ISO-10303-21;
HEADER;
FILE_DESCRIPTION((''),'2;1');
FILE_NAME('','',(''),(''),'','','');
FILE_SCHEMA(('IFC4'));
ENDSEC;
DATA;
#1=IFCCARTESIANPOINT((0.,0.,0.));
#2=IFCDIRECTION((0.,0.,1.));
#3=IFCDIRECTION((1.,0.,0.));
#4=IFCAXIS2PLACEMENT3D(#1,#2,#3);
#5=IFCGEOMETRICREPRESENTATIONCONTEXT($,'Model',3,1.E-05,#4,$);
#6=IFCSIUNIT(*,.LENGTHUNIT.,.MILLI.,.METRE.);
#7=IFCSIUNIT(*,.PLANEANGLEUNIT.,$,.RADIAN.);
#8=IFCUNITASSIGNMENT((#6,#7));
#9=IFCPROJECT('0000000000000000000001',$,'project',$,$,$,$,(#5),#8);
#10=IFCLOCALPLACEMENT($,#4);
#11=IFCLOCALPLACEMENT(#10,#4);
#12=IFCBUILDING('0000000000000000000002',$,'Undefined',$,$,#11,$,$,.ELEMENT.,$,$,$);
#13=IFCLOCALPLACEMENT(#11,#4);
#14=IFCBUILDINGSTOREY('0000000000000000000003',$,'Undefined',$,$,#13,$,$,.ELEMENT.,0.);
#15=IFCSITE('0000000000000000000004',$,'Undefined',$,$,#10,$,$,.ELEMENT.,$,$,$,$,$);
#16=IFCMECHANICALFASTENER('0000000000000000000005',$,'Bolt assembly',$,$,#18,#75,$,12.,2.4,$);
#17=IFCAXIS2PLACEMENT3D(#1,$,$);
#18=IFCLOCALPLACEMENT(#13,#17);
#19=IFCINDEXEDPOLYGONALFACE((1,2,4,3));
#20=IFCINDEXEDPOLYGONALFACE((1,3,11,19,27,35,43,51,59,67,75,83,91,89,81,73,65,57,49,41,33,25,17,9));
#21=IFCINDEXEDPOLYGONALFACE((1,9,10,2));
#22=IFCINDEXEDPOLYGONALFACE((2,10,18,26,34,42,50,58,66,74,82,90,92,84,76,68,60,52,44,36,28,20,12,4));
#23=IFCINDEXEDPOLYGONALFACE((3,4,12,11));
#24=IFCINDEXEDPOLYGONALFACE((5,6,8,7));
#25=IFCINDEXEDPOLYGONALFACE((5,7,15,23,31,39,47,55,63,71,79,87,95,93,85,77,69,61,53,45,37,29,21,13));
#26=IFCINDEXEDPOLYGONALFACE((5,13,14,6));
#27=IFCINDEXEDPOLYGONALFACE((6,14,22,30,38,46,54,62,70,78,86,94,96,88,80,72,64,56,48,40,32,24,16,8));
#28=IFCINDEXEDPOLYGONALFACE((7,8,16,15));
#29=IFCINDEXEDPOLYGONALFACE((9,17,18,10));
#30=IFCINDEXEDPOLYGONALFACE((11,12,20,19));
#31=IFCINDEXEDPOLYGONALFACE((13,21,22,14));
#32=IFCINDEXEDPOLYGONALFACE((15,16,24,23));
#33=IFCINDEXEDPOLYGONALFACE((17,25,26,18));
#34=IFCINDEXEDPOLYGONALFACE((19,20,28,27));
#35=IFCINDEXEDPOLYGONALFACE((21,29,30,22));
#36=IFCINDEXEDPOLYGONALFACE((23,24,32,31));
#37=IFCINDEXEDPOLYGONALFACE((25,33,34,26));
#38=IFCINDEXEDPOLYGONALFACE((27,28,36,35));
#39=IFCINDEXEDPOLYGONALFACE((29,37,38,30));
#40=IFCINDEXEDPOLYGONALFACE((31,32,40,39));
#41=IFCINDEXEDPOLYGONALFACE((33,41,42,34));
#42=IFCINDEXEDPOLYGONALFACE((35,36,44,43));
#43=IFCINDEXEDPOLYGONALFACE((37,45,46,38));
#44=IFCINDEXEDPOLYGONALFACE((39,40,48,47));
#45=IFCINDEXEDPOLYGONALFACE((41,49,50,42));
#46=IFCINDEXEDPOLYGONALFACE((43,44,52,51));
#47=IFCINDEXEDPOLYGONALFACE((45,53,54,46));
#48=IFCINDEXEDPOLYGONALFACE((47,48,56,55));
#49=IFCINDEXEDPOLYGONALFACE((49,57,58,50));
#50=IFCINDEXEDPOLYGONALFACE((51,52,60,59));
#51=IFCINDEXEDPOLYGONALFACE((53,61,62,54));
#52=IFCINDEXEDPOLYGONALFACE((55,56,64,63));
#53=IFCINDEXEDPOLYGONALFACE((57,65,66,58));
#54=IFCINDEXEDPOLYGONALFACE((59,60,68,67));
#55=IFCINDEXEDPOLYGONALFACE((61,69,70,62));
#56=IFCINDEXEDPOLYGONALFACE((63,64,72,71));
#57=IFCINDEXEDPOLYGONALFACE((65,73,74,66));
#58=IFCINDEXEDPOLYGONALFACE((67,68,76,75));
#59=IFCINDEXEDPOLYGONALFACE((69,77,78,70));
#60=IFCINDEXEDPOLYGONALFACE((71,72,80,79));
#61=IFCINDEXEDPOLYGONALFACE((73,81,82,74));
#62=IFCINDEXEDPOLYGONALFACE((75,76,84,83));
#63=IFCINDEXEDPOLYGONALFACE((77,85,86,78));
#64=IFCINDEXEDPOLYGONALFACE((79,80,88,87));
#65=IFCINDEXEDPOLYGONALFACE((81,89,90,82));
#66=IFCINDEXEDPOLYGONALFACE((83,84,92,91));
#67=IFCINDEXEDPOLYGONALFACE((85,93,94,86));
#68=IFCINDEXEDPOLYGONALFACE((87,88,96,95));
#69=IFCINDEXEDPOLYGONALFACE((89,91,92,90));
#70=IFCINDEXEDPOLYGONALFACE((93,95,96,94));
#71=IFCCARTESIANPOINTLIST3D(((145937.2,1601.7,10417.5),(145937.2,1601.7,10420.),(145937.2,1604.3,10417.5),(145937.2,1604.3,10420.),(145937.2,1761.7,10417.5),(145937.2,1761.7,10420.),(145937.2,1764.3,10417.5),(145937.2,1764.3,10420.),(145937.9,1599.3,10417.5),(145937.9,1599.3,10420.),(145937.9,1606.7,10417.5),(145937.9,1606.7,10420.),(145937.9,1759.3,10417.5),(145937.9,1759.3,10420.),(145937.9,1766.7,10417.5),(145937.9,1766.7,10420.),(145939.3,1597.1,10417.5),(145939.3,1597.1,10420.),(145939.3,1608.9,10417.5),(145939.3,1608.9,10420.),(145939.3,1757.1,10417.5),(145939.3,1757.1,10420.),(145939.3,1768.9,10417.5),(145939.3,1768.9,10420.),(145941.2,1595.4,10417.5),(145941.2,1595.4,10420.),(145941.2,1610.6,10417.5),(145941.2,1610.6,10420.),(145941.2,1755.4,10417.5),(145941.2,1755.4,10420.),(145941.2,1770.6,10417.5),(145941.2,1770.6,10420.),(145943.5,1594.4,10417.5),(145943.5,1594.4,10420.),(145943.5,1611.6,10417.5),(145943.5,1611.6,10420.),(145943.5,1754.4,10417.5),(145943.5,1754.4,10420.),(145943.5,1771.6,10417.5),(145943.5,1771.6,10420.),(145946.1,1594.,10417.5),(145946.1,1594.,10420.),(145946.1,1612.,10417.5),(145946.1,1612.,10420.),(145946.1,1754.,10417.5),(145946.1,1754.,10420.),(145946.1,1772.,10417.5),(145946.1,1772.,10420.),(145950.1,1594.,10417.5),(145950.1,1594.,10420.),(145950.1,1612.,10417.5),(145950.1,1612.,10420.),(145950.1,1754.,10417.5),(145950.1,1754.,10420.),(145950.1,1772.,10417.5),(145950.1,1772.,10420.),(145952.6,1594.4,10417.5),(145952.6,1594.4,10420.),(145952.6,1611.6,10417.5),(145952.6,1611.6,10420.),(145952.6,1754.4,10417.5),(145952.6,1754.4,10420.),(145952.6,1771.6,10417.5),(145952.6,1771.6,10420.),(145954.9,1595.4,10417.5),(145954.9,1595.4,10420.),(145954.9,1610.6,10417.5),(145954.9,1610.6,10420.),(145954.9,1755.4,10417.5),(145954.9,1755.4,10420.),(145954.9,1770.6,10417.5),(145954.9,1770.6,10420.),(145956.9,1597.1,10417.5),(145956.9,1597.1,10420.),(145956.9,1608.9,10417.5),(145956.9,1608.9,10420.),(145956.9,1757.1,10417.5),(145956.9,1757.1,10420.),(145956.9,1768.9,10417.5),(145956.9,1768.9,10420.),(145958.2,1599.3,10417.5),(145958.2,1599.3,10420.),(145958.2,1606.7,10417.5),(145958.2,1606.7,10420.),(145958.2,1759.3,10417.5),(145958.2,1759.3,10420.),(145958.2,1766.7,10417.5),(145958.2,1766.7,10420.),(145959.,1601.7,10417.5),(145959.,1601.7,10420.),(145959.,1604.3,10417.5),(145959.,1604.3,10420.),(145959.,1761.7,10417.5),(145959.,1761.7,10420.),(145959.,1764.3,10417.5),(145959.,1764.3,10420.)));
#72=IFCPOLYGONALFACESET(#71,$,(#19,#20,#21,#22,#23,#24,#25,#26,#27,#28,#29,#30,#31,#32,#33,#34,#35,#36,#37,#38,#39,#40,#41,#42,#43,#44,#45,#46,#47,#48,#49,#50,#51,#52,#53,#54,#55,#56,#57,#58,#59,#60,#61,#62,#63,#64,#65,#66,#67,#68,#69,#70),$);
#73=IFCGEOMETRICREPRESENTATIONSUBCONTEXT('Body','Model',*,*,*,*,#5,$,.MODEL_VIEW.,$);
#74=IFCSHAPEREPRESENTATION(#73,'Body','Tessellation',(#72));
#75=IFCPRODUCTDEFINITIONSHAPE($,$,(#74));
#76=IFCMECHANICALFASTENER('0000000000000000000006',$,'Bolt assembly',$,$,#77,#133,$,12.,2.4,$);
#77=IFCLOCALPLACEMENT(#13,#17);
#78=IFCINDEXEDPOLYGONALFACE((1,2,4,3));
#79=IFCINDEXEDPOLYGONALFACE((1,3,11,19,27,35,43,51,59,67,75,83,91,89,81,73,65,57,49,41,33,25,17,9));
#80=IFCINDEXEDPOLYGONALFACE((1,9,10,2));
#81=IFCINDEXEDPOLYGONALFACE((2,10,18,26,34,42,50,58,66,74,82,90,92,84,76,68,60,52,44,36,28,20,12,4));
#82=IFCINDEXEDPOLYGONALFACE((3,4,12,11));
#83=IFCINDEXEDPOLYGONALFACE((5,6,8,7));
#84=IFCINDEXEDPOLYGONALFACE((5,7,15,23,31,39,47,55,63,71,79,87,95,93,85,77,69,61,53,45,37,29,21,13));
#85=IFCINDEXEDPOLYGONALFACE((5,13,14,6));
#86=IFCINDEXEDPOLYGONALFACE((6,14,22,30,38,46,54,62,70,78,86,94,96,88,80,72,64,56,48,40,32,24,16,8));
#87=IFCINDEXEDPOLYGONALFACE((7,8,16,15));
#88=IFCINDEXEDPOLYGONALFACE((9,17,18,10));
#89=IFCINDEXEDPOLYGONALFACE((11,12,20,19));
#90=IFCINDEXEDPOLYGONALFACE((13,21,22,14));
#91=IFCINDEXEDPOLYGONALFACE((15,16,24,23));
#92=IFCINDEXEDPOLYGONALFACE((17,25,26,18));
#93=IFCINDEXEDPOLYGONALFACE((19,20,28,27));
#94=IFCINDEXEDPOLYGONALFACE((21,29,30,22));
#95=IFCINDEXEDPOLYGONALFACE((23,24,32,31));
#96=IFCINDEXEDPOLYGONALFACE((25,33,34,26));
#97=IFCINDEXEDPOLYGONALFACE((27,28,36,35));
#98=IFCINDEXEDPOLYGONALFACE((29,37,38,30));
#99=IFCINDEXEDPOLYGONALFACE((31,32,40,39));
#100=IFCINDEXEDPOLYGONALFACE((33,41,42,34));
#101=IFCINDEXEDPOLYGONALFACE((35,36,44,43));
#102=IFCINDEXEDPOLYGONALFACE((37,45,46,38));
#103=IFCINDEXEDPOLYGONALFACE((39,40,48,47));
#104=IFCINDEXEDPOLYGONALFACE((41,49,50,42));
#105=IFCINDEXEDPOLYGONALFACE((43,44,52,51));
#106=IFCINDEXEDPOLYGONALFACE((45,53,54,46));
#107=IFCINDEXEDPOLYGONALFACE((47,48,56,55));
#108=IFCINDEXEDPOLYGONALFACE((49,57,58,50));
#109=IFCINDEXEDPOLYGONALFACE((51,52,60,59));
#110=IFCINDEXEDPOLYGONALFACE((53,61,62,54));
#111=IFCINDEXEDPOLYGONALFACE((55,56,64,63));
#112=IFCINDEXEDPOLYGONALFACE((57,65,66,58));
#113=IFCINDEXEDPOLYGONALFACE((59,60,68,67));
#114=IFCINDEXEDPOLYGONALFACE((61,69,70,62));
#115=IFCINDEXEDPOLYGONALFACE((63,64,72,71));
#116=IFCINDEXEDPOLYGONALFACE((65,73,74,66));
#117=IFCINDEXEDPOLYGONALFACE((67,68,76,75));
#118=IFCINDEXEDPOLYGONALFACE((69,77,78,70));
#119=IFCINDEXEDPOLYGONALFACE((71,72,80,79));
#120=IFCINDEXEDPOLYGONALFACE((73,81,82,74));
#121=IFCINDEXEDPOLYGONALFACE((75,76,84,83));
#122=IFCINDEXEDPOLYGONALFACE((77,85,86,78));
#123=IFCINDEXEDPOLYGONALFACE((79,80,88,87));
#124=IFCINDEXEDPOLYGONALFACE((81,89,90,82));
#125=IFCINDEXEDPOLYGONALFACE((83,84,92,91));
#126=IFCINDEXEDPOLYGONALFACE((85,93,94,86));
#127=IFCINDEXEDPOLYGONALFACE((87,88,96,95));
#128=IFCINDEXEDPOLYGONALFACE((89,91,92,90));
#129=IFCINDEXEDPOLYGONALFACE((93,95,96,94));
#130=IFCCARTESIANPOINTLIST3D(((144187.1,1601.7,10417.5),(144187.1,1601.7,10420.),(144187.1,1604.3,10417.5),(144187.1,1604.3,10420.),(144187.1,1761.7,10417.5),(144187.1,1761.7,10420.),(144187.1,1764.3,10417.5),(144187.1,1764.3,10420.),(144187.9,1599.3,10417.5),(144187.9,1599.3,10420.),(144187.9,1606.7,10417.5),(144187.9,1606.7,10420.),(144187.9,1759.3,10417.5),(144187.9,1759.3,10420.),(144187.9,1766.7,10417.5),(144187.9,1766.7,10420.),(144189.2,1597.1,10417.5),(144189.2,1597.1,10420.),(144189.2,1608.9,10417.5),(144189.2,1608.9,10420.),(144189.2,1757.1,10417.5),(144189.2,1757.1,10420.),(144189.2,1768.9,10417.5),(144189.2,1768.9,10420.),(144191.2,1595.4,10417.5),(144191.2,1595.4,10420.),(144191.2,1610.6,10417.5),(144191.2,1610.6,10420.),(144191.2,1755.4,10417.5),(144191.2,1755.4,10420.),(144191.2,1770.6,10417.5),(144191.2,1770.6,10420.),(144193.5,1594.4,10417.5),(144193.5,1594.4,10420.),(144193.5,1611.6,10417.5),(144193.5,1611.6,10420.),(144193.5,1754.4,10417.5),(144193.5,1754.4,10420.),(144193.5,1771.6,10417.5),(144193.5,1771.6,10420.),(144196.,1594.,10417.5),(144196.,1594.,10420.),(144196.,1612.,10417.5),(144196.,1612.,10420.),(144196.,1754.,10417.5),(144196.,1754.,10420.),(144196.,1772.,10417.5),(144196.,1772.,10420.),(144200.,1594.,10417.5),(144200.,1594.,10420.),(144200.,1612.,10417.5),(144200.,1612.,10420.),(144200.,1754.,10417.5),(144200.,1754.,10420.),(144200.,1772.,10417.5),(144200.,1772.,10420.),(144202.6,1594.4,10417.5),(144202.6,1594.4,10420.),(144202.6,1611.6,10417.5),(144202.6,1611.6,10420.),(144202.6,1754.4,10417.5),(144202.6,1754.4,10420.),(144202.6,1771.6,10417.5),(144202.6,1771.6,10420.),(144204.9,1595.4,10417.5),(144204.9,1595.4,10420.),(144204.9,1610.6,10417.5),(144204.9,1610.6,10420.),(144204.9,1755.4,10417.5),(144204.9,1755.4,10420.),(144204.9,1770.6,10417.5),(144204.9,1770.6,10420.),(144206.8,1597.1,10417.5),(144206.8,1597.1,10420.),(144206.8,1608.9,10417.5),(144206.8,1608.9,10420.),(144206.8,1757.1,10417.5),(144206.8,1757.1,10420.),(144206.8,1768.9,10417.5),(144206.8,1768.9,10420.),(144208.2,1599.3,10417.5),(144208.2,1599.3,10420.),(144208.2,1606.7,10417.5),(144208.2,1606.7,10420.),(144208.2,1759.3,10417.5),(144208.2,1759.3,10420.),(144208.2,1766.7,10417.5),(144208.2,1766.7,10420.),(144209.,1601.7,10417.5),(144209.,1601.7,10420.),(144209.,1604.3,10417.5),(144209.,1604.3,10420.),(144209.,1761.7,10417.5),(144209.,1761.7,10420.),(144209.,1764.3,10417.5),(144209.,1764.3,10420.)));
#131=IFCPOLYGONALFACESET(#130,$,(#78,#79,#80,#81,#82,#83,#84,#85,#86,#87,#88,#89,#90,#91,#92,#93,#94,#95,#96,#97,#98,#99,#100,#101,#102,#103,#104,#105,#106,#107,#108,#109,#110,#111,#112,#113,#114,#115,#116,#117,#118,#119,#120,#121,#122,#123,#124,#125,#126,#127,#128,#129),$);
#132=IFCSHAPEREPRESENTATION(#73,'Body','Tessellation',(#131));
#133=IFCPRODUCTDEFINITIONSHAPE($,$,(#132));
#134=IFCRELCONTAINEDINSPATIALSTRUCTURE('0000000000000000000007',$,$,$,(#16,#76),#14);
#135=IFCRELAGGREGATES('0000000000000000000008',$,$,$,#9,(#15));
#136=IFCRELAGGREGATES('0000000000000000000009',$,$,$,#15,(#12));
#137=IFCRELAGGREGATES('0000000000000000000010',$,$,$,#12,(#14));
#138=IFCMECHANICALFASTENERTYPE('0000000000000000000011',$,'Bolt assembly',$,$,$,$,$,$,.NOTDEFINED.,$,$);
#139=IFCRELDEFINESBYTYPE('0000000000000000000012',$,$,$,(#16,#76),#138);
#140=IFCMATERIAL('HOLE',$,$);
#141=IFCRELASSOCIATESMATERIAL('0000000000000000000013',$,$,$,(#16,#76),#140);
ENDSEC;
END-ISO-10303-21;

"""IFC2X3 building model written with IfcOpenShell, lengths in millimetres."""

from ifc_helpers import new_model, si_unit, frame, frame_2d, origin_with_axes, place, context, subcontext, project, spatial, polyline, circle_curve, parameter, trimmed, segment, composite_curve, outline, extrude, source, transform, mapped, material, type_object, element, save


model = new_model("IFC2X3")

# Units and contexts
model_context = context("Model", 3, precision=1e-05, world=origin_with_axes())
body_context = subcontext(model_context, "Body", "Model", "MODEL_VIEW")
ifc_project = project(units=[si_unit("LENGTHUNIT", "METRE", prefix="MILLI"), si_unit("PLANEANGLEUNIT", "RADIAN")], contexts=[model_context])

# Site, building, storey
site_placement = place(None, origin_with_axes())
site = spatial("IfcSite", under=ifc_project, at=site_placement, Name="Undefined", CompositionType="ELEMENT")
building_placement = place(site_placement, origin_with_axes())
building = spatial("IfcBuilding", under=site, at=building_placement, Name="Undefined", CompositionType="ELEMENT")
storey_placement = place(building_placement, origin_with_axes())
storey = spatial("IfcBuildingStorey", under=building, at=storey_placement, Name="Undefined", CompositionType="ELEMENT", Elevation=0.0)

# Mechanical fasteners
mechanical_fastener_type = type_object("IfcMechanicalFastenerType", Name="Bolt assembly")
ifc_material_1 = material(Name="HOLE")
shared_shape_1 = source(origin_with_axes(), body_context, "Body", "SweptSolid", [
    extrude(outline(composite_curve([segment(polyline([(-2.0, 9.0), (2.0, 9.0)]), True, "CONTINUOUS"), segment(trimmed(circle_curve(frame_2d((2.0, 0.0), x_axis=(0.0, 1.0)), 9.0), [parameter(0.0)], [parameter(3.141593)], False, "PARAMETER"), True, "CONTINUOUS"), segment(polyline([(2.0, -9.0), (-2.0, -9.0)]), True, "CONTINUOUS"), segment(trimmed(circle_curve(frame_2d((-2.0, 0.0), x_axis=(0.0, -1.0)), 9.0), [parameter(0.0)], [parameter(3.141593)], False, "PARAMETER"), True, "DISCONTINUOUS")], self_intersect=False)), frame((0.0, -2.4, 0.0), z_axis=(0.0, 1.0, 0.0), x_axis=(1.0, 0.0, 0.0)), (0.0, 0.0, 1.0), 2.5),
])
mechanical_fastener_1_placement = place(storey_placement, frame((145948.1, 1683.0, 10417.6), z_axis=(0.0, -1.0, 0.0), x_axis=(-1.0, 0.0, 0.0)))
element("IfcMechanicalFastener", 1, at=mechanical_fastener_1_placement, inside=storey, type_object=mechanical_fastener_type, material=ifc_material_1, Name="Bolt assembly", NominalDiameter=12.0, NominalLength=2.4, context=body_context, shape_type="MappedRepresentation", body=[
    mapped(shared_shape_1, transform((0.0, 0.0, -80.0))),
    mapped(shared_shape_1, transform((0.0, 0.0, 80.0))),
])
shared_shape_2 = source(origin_with_axes(), body_context, "Body", "SweptSolid", [
    extrude(outline(composite_curve([segment(polyline([(-2.0, 9.0), (2.0, 9.0)]), True, "CONTINUOUS"), segment(trimmed(circle_curve(frame_2d((2.0, 0.0), x_axis=(0.0, 1.0)), 9.0), [parameter(0.0)], [parameter(3.141593)], False, "PARAMETER"), True, "CONTINUOUS"), segment(polyline([(2.0, -9.0), (-2.0, -9.0)]), True, "CONTINUOUS"), segment(trimmed(circle_curve(frame_2d((-2.0, 0.0), x_axis=(0.0, -1.0)), 9.0), [parameter(0.0)], [parameter(3.141593)], False, "PARAMETER"), True, "DISCONTINUOUS")], self_intersect=False)), frame((0.0, -2.4, 0.0), z_axis=(0.0, 1.0, 0.0), x_axis=(1.0, 0.0, 0.0)), (0.0, 0.0, 1.0), 2.5),
])
mechanical_fastener_2_placement = place(storey_placement, frame((144198.0, 1683.0, 10417.6), z_axis=(0.0, -1.0, 0.0), x_axis=(-1.0, 0.0, 0.0)))
element("IfcMechanicalFastener", 2, at=mechanical_fastener_2_placement, inside=storey, type_object=mechanical_fastener_type, material=ifc_material_1, Name="Bolt assembly", NominalDiameter=12.0, NominalLength=2.4, context=body_context, shape_type="MappedRepresentation", body=[
    mapped(shared_shape_2, transform((0.0, 0.0, -80.0))),
    mapped(shared_shape_2, transform((0.0, 0.0, 80.0))),
])

save(model, "model.ifc")
